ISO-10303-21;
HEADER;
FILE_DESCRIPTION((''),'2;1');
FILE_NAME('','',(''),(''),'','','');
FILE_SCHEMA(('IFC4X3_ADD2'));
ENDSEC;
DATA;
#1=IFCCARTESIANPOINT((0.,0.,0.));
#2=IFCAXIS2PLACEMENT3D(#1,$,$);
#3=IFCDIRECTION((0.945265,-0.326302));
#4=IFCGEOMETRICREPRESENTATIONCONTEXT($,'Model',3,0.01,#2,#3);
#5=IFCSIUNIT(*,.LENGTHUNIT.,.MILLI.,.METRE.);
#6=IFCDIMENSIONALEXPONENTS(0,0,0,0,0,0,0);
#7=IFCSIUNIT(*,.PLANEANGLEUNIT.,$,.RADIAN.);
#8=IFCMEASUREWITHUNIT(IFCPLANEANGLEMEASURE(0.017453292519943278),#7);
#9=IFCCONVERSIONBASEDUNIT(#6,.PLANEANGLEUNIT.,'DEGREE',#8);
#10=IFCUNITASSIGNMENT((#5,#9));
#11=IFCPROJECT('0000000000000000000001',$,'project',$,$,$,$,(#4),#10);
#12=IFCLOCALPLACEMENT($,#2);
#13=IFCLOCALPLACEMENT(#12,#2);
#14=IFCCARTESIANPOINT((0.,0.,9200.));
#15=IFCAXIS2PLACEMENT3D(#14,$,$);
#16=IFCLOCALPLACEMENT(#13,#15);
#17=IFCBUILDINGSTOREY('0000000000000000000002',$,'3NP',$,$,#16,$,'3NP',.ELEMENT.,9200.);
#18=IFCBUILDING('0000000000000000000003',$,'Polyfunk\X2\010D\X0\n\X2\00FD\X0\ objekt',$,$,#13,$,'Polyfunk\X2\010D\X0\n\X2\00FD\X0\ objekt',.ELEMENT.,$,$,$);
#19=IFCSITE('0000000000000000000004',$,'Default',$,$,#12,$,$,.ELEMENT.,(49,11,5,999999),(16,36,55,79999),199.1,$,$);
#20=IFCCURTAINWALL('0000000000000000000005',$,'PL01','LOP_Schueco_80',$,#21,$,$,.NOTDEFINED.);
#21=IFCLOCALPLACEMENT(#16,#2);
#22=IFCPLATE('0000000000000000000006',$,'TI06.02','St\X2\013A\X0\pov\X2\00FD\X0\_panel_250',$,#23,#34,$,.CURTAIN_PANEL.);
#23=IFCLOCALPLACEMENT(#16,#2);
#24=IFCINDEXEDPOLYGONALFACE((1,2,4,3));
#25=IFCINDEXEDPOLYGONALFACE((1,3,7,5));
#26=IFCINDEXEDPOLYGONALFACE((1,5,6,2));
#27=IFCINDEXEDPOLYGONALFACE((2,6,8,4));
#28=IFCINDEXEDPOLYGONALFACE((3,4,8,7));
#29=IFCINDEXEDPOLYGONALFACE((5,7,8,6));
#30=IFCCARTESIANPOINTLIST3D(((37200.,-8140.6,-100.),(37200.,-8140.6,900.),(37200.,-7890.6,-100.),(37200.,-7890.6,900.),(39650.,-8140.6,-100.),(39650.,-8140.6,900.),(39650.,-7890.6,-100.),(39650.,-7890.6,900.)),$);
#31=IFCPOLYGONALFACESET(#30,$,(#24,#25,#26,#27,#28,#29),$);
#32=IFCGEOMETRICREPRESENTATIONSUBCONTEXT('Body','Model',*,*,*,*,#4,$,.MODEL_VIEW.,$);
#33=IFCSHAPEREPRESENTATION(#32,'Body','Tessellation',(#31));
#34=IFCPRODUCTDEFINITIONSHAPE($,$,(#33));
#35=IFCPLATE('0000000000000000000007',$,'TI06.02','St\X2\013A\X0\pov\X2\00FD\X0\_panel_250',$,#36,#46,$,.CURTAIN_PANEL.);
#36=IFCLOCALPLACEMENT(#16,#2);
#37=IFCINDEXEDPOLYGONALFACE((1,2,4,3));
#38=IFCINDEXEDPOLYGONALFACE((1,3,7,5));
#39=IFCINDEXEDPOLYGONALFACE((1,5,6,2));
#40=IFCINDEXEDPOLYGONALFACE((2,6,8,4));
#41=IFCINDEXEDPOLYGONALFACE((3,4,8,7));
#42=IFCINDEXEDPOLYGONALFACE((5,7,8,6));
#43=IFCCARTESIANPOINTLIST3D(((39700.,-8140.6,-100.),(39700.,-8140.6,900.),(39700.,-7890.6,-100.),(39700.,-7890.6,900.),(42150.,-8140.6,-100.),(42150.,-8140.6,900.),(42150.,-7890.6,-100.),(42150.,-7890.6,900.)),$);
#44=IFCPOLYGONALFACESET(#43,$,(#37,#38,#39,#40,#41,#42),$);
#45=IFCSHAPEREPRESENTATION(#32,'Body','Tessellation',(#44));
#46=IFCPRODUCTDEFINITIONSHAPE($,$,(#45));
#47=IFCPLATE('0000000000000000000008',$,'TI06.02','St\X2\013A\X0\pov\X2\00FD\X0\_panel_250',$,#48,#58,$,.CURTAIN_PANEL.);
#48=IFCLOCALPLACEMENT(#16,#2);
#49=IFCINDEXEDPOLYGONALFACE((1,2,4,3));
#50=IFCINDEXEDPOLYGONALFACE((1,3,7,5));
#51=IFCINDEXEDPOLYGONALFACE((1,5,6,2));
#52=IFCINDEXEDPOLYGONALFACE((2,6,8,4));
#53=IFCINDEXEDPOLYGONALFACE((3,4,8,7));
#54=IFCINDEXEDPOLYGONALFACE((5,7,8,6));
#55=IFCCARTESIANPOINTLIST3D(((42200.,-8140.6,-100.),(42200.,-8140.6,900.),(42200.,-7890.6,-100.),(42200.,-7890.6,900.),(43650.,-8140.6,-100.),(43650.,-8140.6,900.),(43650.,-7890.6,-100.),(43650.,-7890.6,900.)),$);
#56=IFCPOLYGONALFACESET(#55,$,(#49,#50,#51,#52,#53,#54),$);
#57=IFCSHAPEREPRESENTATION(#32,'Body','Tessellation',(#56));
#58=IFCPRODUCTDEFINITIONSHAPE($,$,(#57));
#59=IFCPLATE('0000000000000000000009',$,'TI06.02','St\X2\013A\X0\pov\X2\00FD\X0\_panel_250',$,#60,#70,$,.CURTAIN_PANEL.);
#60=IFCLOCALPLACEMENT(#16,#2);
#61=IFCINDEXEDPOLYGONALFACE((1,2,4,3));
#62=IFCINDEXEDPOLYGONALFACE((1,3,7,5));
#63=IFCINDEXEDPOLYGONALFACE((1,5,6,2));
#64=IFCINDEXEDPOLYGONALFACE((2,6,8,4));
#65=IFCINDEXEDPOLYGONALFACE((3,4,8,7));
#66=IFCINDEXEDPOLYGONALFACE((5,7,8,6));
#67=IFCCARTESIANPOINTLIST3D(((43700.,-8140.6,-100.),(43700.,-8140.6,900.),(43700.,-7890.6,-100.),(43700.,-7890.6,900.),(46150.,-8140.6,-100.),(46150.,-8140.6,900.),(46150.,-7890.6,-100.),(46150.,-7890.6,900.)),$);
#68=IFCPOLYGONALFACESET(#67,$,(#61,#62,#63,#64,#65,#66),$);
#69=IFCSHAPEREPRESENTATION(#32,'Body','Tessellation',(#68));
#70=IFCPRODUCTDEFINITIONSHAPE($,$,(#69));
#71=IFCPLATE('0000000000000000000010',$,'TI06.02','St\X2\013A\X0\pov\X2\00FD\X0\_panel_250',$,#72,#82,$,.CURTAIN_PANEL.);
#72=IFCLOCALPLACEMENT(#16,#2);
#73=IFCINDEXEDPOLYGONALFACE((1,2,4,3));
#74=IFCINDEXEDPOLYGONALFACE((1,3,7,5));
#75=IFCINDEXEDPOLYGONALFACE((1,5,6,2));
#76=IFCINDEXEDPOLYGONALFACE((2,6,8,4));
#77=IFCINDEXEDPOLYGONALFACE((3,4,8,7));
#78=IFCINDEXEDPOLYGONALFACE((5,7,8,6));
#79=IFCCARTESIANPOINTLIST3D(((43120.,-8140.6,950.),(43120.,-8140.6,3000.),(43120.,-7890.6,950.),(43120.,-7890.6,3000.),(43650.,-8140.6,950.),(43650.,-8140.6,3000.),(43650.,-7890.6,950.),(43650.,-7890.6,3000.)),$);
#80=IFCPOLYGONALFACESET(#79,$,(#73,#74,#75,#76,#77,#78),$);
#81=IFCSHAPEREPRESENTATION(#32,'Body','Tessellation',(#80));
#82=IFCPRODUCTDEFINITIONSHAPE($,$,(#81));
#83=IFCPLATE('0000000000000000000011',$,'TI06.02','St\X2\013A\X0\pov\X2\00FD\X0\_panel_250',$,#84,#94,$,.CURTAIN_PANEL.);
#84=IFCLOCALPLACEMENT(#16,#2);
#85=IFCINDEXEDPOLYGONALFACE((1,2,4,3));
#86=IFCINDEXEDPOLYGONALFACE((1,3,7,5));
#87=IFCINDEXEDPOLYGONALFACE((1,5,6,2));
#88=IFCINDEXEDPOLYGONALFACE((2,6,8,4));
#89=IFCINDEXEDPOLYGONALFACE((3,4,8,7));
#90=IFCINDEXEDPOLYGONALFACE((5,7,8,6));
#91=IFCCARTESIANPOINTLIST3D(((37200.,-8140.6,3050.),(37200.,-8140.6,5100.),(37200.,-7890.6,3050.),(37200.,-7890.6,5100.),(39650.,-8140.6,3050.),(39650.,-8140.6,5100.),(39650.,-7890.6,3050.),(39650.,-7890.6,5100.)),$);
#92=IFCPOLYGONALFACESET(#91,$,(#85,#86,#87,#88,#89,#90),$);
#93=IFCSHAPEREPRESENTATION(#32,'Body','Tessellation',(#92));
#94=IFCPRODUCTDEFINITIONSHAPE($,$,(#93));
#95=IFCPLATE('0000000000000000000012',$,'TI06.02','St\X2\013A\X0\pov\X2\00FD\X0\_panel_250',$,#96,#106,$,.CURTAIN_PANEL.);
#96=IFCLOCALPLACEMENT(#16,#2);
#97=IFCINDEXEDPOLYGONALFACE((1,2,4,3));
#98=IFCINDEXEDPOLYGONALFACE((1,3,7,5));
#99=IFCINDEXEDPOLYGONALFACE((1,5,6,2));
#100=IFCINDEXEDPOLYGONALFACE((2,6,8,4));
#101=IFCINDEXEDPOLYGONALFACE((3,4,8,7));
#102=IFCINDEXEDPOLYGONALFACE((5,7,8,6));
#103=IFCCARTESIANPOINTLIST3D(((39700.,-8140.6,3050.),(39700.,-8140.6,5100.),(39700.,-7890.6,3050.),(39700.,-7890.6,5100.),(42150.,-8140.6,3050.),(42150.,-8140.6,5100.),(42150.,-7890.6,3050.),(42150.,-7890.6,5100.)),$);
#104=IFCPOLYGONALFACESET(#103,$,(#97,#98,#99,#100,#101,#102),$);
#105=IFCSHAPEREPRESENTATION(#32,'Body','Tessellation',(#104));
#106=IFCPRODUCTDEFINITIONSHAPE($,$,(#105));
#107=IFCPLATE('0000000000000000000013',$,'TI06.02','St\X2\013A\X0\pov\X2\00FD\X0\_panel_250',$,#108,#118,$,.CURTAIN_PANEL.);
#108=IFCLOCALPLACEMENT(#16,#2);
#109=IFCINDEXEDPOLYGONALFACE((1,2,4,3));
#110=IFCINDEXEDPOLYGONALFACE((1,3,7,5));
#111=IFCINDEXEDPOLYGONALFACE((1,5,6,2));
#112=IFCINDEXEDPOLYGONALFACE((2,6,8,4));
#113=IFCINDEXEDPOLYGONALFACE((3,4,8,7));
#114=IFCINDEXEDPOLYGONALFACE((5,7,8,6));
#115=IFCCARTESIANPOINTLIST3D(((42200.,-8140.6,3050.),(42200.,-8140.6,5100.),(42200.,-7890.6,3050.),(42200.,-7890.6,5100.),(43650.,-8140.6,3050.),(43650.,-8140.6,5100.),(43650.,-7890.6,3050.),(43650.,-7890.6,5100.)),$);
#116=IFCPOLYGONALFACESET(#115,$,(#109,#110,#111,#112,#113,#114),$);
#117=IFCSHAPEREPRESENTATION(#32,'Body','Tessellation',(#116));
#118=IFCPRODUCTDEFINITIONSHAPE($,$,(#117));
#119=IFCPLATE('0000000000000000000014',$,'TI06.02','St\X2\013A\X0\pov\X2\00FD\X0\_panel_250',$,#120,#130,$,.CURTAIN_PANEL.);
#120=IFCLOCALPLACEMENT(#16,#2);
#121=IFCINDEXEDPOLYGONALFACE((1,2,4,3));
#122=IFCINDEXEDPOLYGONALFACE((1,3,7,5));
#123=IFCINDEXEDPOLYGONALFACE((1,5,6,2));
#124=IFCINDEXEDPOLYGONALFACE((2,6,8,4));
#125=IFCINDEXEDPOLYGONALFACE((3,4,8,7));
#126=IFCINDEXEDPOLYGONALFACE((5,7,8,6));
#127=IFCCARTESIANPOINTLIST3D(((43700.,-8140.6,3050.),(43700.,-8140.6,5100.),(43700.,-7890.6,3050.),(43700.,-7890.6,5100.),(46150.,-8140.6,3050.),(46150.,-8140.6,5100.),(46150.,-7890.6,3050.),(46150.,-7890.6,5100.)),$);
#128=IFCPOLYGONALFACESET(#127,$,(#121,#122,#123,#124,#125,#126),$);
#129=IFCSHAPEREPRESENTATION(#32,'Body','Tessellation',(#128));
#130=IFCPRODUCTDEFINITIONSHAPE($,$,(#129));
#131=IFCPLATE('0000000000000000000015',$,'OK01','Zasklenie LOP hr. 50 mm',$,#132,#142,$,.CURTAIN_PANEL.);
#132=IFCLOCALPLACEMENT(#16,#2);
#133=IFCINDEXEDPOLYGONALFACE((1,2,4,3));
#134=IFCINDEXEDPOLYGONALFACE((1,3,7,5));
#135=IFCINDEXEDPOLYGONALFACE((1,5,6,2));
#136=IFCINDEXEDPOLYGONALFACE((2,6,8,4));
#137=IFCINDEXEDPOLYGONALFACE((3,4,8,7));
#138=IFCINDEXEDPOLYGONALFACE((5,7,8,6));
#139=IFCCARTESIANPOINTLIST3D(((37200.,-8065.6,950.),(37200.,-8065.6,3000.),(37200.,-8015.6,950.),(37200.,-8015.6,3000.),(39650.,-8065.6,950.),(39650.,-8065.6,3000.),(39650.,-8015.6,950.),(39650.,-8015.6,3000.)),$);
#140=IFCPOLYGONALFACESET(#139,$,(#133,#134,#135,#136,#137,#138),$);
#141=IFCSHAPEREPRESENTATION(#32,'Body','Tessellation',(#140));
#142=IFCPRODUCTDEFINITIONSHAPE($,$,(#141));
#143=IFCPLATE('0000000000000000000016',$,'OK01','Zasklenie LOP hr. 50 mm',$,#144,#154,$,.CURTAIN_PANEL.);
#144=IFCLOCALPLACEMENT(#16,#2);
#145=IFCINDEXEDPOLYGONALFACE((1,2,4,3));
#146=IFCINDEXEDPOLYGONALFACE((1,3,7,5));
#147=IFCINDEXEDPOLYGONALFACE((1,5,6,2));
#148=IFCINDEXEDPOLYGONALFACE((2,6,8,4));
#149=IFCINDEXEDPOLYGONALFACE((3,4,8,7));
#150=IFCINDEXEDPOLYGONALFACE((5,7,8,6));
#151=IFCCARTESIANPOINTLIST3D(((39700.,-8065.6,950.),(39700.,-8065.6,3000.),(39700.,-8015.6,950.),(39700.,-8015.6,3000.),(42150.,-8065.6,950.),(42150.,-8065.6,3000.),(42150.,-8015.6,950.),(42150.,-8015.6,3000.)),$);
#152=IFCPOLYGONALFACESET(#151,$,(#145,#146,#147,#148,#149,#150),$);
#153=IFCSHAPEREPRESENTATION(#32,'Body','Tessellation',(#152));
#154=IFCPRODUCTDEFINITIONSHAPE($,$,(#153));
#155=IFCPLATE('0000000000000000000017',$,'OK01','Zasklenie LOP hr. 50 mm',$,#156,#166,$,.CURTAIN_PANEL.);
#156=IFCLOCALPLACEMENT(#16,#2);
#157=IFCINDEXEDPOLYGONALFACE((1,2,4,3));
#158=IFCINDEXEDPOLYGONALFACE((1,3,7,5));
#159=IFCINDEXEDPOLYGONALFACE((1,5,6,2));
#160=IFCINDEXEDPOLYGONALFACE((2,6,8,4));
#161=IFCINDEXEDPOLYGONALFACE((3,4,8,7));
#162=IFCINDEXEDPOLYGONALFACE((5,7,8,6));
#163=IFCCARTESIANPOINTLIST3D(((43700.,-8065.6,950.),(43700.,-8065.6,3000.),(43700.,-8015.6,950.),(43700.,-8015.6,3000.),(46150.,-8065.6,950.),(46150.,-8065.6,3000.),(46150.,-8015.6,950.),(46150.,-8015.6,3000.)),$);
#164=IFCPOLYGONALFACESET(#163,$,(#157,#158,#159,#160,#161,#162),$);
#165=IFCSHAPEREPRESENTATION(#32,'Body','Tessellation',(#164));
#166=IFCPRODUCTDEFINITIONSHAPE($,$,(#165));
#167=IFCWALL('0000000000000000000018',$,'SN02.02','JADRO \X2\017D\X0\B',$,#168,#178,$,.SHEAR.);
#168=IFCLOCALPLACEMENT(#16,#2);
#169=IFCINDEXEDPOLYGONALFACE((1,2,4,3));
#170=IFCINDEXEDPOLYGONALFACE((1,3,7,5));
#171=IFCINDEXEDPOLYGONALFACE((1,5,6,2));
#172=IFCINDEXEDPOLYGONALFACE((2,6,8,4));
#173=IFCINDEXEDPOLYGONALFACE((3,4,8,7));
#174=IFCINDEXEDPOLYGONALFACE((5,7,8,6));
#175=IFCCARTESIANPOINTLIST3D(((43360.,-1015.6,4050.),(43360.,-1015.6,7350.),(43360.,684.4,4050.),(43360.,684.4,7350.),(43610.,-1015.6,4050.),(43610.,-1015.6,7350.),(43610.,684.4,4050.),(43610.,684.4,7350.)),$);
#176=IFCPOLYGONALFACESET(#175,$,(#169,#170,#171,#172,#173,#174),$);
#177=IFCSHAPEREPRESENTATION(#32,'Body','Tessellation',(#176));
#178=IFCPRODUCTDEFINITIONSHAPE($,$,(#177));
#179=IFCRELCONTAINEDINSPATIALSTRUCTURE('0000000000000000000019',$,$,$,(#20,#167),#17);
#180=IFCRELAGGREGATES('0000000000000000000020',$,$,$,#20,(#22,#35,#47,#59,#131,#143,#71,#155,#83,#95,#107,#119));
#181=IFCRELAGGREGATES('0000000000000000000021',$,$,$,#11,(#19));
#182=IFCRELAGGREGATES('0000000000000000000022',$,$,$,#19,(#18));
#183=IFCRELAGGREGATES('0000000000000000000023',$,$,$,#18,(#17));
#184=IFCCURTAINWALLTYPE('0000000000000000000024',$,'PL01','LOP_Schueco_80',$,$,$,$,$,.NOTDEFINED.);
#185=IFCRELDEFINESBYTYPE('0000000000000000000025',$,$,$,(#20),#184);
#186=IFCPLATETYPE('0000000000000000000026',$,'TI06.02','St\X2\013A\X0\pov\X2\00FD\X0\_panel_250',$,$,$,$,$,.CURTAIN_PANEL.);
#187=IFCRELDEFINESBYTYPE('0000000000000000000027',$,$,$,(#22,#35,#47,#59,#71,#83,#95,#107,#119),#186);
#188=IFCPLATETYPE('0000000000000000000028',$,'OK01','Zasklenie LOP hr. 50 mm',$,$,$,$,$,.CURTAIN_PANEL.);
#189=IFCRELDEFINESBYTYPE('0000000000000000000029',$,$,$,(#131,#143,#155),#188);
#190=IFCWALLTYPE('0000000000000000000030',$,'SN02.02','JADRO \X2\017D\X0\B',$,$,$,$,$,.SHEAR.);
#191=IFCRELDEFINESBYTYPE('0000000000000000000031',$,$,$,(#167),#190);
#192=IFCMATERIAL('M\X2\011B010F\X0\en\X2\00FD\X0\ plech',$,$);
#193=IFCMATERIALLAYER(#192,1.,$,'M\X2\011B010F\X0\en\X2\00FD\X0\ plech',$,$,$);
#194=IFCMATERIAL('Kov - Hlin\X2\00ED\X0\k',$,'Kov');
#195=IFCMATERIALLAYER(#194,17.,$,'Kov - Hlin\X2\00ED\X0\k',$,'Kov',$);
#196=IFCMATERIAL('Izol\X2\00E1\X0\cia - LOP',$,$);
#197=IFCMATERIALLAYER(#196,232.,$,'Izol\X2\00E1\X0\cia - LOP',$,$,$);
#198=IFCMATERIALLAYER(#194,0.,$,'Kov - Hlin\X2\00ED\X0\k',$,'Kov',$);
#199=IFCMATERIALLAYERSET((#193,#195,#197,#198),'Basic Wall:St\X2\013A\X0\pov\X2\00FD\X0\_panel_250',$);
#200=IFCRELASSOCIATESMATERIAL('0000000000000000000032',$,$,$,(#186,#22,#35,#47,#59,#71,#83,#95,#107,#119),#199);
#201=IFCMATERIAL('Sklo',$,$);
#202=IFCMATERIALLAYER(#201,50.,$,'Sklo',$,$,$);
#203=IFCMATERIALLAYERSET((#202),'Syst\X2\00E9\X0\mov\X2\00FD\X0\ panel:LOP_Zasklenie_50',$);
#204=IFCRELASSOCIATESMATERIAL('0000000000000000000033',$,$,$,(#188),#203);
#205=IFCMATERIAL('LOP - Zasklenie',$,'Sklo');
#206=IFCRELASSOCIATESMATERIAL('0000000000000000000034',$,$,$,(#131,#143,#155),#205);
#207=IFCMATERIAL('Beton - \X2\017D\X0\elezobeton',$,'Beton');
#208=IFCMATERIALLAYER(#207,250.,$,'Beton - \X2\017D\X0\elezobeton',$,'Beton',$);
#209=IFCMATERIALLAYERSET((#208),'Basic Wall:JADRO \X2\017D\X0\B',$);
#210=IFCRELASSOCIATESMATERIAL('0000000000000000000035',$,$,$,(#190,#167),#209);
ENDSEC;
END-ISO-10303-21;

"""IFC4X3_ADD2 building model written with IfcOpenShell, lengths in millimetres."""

from ifc_helpers import new_model, entity, si_unit, converted_unit, direction, frame, frame_2d, origin, origin_2d_with_axis, place, context, subcontext, project, spatial, polyline, rectangle, extrude, clip, bounded_halfspace, source, transform, mapped, material, layer, layer_set, layer_usage, type_object, type_shapes, element, aggregate, save


model = new_model("IFC4X3_ADD2")

# Units and contexts
model_context = context("Model", 3, precision=0.01, world=origin(), true_north=direction((0.945265, -0.326302)))
body_context = subcontext(model_context, "Body", "Model", "MODEL_VIEW")
ifc_project = project(units=[si_unit("LENGTHUNIT", "METRE", prefix="MILLI"), converted_unit("PLANEANGLEUNIT", "DEGREE", entity("IfcPlaneAngleMeasure", 0.017453292519943278), si_unit("PLANEANGLEUNIT", "RADIAN"), dimensions=[0, 0, 0, 0, 0, 0, 0])], contexts=[model_context])

# Site, building, storey
site_placement = place(None, origin())
site = spatial("IfcSite", under=ifc_project, at=site_placement, Name="Default", CompositionType="ELEMENT", RefLatitude=(49, 11, 5, 999999), RefLongitude=(16, 36, 55, 79999), RefElevation=199.1)
building_placement = place(site_placement, origin())
building = spatial("IfcBuilding", under=site, at=building_placement, Name="Polyfunkčný objekt", LongName="Polyfunkčný objekt", CompositionType="ELEMENT")
storey_placement = place(building_placement, frame((0.0, 0.0, 9200.0)))
storey = spatial("IfcBuildingStorey", under=building, at=storey_placement, Name="3NP", LongName="3NP", CompositionType="ELEMENT", Elevation=9200.0)

# Curtain wall, plates
curtain_wall_type = type_object("IfcCurtainWallType", Name="PL01", Description="LOP_Schueco_80", PredefinedType="NOTDEFINED")
curtain_wall_placement = place(storey_placement, frame((0.0, 0.0, -9200.0)))
curtain_wall = element("IfcCurtainWall", 1, at=curtain_wall_placement, inside=storey, type_object=curtain_wall_type, Name="PL01", Description="LOP_Schueco_80", PredefinedType="NOTDEFINED")
ifc_material_1 = material(Name="Měďený plech")
ifc_layer_1 = layer(ifc_material_1, 1.0, Name="Měďený plech")
ifc_material_2 = material(Name="Kov - Hliník", Category="Kov")
ifc_layer_2 = layer(ifc_material_2, 17.0, Name="Kov - Hliník", Category="Kov")
ifc_material_3 = material(Name="Izolácia - LOP")
ifc_layer_3 = layer(ifc_material_3, 232.0, Name="Izolácia - LOP")
ifc_layer_4 = layer(ifc_material_2, 0.0, Name="Kov - Hliník", Category="Kov")
ifc_layer_set_1 = layer_set([ifc_layer_1, ifc_layer_2, ifc_layer_3, ifc_layer_4], Name="Basic Wall:Stĺpový_panel_250")
ifc_layer_usage_1 = layer_usage(ifc_layer_set_1, "AXIS2", "POSITIVE", -125.0)
plate_type_1 = type_object("IfcPlateType", Name="TI06.02", Description="Stĺpový_panel_250", PredefinedType="CURTAIN_PANEL", material=ifc_layer_set_1)
plate_1_placement = place(storey_placement, frame((37200.0, -8015.6, -100.0)))
plate_1 = element("IfcPlate", 2, at=plate_1_placement, type_object=plate_type_1, material=ifc_layer_usage_1, Name="TI06.02", Description="Stĺpový_panel_250", PredefinedType="CURTAIN_PANEL", context=body_context, shape_type="SweptSolid", body=[
    extrude(rectangle(XDim=250.0, YDim=2450.0, at=frame_2d((0.0, 0.0), x_axis=(1.0, 0.0))), frame((1225.0, 0.0, 0.0), z_axis=(0.0, 0.0, 1.0), x_axis=(0.0, 1.0, 0.0)), (0.0, 0.0, 1.0), 1000.0),
])
ifc_layer_usage_2 = layer_usage(ifc_layer_set_1, "AXIS2", "POSITIVE", -125.0)
plate_2_placement = place(storey_placement, frame((39700.0, -8015.6, -100.0)))
plate_2 = element("IfcPlate", 3, at=plate_2_placement, type_object=plate_type_1, material=ifc_layer_usage_2, Name="TI06.02", Description="Stĺpový_panel_250", PredefinedType="CURTAIN_PANEL", context=body_context, shape_type="SweptSolid", body=[
    extrude(rectangle(XDim=250.0, YDim=2450.0, at=frame_2d((0.0, 0.0), x_axis=(1.0, 0.0))), frame((1225.0, 0.0, 0.0), z_axis=(0.0, 0.0, 1.0), x_axis=(0.0, 1.0, 0.0)), (0.0, 0.0, 1.0), 1000.0),
])
ifc_layer_usage_3 = layer_usage(ifc_layer_set_1, "AXIS2", "POSITIVE", -125.0)
plate_3_placement = place(storey_placement, frame((42200.0, -8015.6, -100.0)))
plate_3 = element("IfcPlate", 4, at=plate_3_placement, type_object=plate_type_1, material=ifc_layer_usage_3, Name="TI06.02", Description="Stĺpový_panel_250", PredefinedType="CURTAIN_PANEL", context=body_context, shape_type="SweptSolid", body=[
    extrude(rectangle(XDim=250.0, YDim=1450.0, at=frame_2d((0.0, 0.0), x_axis=(1.0, 0.0))), frame((725.0, 0.0, 0.0), z_axis=(0.0, 0.0, 1.0), x_axis=(0.0, 1.0, 0.0)), (0.0, 0.0, 1.0), 1000.0),
])
ifc_layer_usage_4 = layer_usage(ifc_layer_set_1, "AXIS2", "POSITIVE", -125.0)
plate_4_placement = place(storey_placement, frame((43700.0, -8015.6, -100.0)))
plate_4 = element("IfcPlate", 5, at=plate_4_placement, type_object=plate_type_1, material=ifc_layer_usage_4, Name="TI06.02", Description="Stĺpový_panel_250", PredefinedType="CURTAIN_PANEL", context=body_context, shape_type="SweptSolid", body=[
    extrude(rectangle(XDim=250.0, YDim=2450.0, at=frame_2d((0.0, 0.0), x_axis=(1.0, 0.0))), frame((1225.0, 0.0, 0.0), z_axis=(0.0, 0.0, 1.0), x_axis=(0.0, 1.0, 0.0)), (0.0, 0.0, 1.0), 1000.0),
])
ifc_layer_usage_5 = layer_usage(ifc_layer_set_1, "AXIS2", "POSITIVE", -125.0)
plate_5_placement = place(storey_placement, frame((43120.0, -8015.6, 950.0)))
plate_5 = element("IfcPlate", 6, at=plate_5_placement, type_object=plate_type_1, material=ifc_layer_usage_5, Name="TI06.02", Description="Stĺpový_panel_250", PredefinedType="CURTAIN_PANEL", context=body_context, shape_type="SweptSolid", body=[
    extrude(rectangle(XDim=250.0, YDim=530.0, at=frame_2d((0.0, 0.0), x_axis=(1.0, 0.0))), frame((265.0, 0.0, 0.0), z_axis=(0.0, 0.0, 1.0), x_axis=(0.0, 1.0, 0.0)), (0.0, 0.0, 1.0), 2050.0),
])
ifc_layer_usage_6 = layer_usage(ifc_layer_set_1, "AXIS2", "POSITIVE", -125.0)
plate_6_placement = place(storey_placement, frame((37200.0, -8015.6, 3050.0)))
plate_6 = element("IfcPlate", 7, at=plate_6_placement, type_object=plate_type_1, material=ifc_layer_usage_6, Name="TI06.02", Description="Stĺpový_panel_250", PredefinedType="CURTAIN_PANEL", context=body_context, shape_type="SweptSolid", body=[
    extrude(rectangle(XDim=250.0, YDim=2450.0, at=frame_2d((0.0, 0.0), x_axis=(1.0, 0.0))), frame((1225.0, 0.0, 0.0), z_axis=(0.0, 0.0, 1.0), x_axis=(0.0, 1.0, 0.0)), (0.0, 0.0, 1.0), 2050.0),
])
ifc_layer_usage_7 = layer_usage(ifc_layer_set_1, "AXIS2", "POSITIVE", -125.0)
plate_7_placement = place(storey_placement, frame((39700.0, -8015.6, 3050.0)))
plate_7 = element("IfcPlate", 8, at=plate_7_placement, type_object=plate_type_1, material=ifc_layer_usage_7, Name="TI06.02", Description="Stĺpový_panel_250", PredefinedType="CURTAIN_PANEL", context=body_context, shape_type="SweptSolid", body=[
    extrude(rectangle(XDim=250.0, YDim=2450.0, at=frame_2d((0.0, 0.0), x_axis=(1.0, 0.0))), frame((1225.0, 0.0, 0.0), z_axis=(0.0, 0.0, 1.0), x_axis=(0.0, 1.0, 0.0)), (0.0, 0.0, 1.0), 2050.0),
])
ifc_layer_usage_8 = layer_usage(ifc_layer_set_1, "AXIS2", "POSITIVE", -125.0)
plate_8_placement = place(storey_placement, frame((42200.0, -8015.6, 3050.0)))
plate_8 = element("IfcPlate", 9, at=plate_8_placement, type_object=plate_type_1, material=ifc_layer_usage_8, Name="TI06.02", Description="Stĺpový_panel_250", PredefinedType="CURTAIN_PANEL", context=body_context, shape_type="SweptSolid", body=[
    extrude(rectangle(XDim=250.0, YDim=1450.0, at=frame_2d((0.0, 0.0), x_axis=(1.0, 0.0))), frame((725.0, 0.0, 0.0), z_axis=(0.0, 0.0, 1.0), x_axis=(0.0, 1.0, 0.0)), (0.0, 0.0, 1.0), 2050.0),
])
ifc_layer_usage_9 = layer_usage(ifc_layer_set_1, "AXIS2", "POSITIVE", -125.0)
plate_9_placement = place(storey_placement, frame((43700.0, -8015.6, 3050.0)))
plate_9 = element("IfcPlate", 10, at=plate_9_placement, type_object=plate_type_1, material=ifc_layer_usage_9, Name="TI06.02", Description="Stĺpový_panel_250", PredefinedType="CURTAIN_PANEL", context=body_context, shape_type="SweptSolid", body=[
    extrude(rectangle(XDim=250.0, YDim=2450.0, at=frame_2d((0.0, 0.0), x_axis=(1.0, 0.0))), frame((1225.0, 0.0, 0.0), z_axis=(0.0, 0.0, 1.0), x_axis=(0.0, 1.0, 0.0)), (0.0, 0.0, 1.0), 2050.0),
])
ifc_material_4 = material(Name="LOP - Zasklenie", Category="Sklo")
ifc_material_5 = material(Name="Sklo")
ifc_layer_5 = layer(ifc_material_5, 50.0, Name="Sklo")
ifc_layer_set_2 = layer_set([ifc_layer_5], Name="Systémový panel:LOP_Zasklenie_50")
plate_type_2 = type_object("IfcPlateType", Name="OK01", Description="Zasklenie LOP hr. 50 mm", PredefinedType="CURTAIN_PANEL", material=ifc_layer_set_2)
shared_shape_1 = source(origin(), body_context, "Body", "SweptSolid", [
    extrude(rectangle(XDim=50.0, YDim=2450.0, at=origin_2d_with_axis()), frame((0.0, -25.0, 0.0), z_axis=(0.0, 0.0, 1.0), x_axis=(0.0, 1.0, 0.0)), (0.0, 0.0, 1.0), 2050.0),
])
type_shapes(plate_type_2, [shared_shape_1])
plate_10_placement = place(curtain_wall_placement, frame((38425.0, -8015.6, 10150.0)))
plate_10 = element("IfcPlate", 11, at=plate_10_placement, type_object=plate_type_2, material=ifc_material_4, Name="OK01", Description="Zasklenie LOP hr. 50 mm", PredefinedType="CURTAIN_PANEL", context=body_context, shape_type="MappedRepresentation", body=[
    mapped(shared_shape_1, transform((0.0, 0.0, 0.0), scale=1.0)),
])
plate_11_placement = place(curtain_wall_placement, frame((40925.0, -8015.6, 10150.0)))
plate_11 = element("IfcPlate", 12, at=plate_11_placement, type_object=plate_type_2, material=ifc_material_4, Name="OK01", Description="Zasklenie LOP hr. 50 mm", PredefinedType="CURTAIN_PANEL", context=body_context, shape_type="MappedRepresentation", body=[
    mapped(shared_shape_1, transform((0.0, 0.0, 0.0), scale=1.0)),
])
plate_12_placement = place(curtain_wall_placement, frame((44925.0, -8015.6, 10150.0)))
plate_12 = element("IfcPlate", 13, at=plate_12_placement, type_object=plate_type_2, material=ifc_material_4, Name="OK01", Description="Zasklenie LOP hr. 50 mm", PredefinedType="CURTAIN_PANEL", context=body_context, shape_type="MappedRepresentation", body=[
    mapped(shared_shape_1, transform((0.0, 0.0, 0.0), scale=1.0)),
])

# Wall
ifc_material_6 = material(Name="Beton - Železobeton", Category="Beton")
ifc_layer_6 = layer(ifc_material_6, 250.0, Name="Beton - Železobeton", Category="Beton")
ifc_layer_set_3 = layer_set([ifc_layer_6], Name="Basic Wall:JADRO ŽB")
wall_type = type_object("IfcWallType", Name="SN02.02", Description="JADRO ŽB", PredefinedType="SHEAR", material=ifc_layer_set_3)
wall_1_placement = place(storey_placement, frame((43485.0, 684.4, 4050.0), z_axis=(0.0, 0.0, 1.0), x_axis=(0.0, -1.0, 0.0)))
element("IfcWall", 14, at=wall_1_placement, inside=storey, type_object=wall_type, material=ifc_layer_set_3, Name="SN02.02", Description="JADRO ŽB", PredefinedType="SHEAR", context=body_context, shape_type="Clipping", body=[
    clip(clip(extrude(rectangle(XDim=1700.0, YDim=250.0, at=frame_2d((850.0, 0.0), x_axis=(-1.0, 0.0))), origin(), (0.0, 0.0, 1.0), 3300.0), bounded_halfspace(frame((1700.0, -125.0, 0.0), z_axis=(0.0, 0.0, 1.0), x_axis=(0.0, -1.0, 0.0)), True, frame((1700.0, -125.0, 0.0)), polyline([(0.0, 0.0), (0.0, 250.0), (-1700.0, 250.0), (-1700.0, 0.0), (0.0, 0.0)]))), bounded_halfspace(frame((0.0, -125.0, 3300.0), z_axis=(0.0, 0.0, -1.0), x_axis=(1.0, 0.0, 0.0)), True, frame((0.0, -125.0, 3300.0)), polyline([(0.0, 0.0), (1700.0, 0.0), (1700.0, 250.0), (0.0, 250.0), (0.0, 0.0)]))),
])

aggregate(curtain_wall, [plate_1, plate_2, plate_3, plate_4, plate_10, plate_11, plate_5, plate_12, plate_6, plate_7, plate_8, plate_9])

save(model, "model.ifc")
